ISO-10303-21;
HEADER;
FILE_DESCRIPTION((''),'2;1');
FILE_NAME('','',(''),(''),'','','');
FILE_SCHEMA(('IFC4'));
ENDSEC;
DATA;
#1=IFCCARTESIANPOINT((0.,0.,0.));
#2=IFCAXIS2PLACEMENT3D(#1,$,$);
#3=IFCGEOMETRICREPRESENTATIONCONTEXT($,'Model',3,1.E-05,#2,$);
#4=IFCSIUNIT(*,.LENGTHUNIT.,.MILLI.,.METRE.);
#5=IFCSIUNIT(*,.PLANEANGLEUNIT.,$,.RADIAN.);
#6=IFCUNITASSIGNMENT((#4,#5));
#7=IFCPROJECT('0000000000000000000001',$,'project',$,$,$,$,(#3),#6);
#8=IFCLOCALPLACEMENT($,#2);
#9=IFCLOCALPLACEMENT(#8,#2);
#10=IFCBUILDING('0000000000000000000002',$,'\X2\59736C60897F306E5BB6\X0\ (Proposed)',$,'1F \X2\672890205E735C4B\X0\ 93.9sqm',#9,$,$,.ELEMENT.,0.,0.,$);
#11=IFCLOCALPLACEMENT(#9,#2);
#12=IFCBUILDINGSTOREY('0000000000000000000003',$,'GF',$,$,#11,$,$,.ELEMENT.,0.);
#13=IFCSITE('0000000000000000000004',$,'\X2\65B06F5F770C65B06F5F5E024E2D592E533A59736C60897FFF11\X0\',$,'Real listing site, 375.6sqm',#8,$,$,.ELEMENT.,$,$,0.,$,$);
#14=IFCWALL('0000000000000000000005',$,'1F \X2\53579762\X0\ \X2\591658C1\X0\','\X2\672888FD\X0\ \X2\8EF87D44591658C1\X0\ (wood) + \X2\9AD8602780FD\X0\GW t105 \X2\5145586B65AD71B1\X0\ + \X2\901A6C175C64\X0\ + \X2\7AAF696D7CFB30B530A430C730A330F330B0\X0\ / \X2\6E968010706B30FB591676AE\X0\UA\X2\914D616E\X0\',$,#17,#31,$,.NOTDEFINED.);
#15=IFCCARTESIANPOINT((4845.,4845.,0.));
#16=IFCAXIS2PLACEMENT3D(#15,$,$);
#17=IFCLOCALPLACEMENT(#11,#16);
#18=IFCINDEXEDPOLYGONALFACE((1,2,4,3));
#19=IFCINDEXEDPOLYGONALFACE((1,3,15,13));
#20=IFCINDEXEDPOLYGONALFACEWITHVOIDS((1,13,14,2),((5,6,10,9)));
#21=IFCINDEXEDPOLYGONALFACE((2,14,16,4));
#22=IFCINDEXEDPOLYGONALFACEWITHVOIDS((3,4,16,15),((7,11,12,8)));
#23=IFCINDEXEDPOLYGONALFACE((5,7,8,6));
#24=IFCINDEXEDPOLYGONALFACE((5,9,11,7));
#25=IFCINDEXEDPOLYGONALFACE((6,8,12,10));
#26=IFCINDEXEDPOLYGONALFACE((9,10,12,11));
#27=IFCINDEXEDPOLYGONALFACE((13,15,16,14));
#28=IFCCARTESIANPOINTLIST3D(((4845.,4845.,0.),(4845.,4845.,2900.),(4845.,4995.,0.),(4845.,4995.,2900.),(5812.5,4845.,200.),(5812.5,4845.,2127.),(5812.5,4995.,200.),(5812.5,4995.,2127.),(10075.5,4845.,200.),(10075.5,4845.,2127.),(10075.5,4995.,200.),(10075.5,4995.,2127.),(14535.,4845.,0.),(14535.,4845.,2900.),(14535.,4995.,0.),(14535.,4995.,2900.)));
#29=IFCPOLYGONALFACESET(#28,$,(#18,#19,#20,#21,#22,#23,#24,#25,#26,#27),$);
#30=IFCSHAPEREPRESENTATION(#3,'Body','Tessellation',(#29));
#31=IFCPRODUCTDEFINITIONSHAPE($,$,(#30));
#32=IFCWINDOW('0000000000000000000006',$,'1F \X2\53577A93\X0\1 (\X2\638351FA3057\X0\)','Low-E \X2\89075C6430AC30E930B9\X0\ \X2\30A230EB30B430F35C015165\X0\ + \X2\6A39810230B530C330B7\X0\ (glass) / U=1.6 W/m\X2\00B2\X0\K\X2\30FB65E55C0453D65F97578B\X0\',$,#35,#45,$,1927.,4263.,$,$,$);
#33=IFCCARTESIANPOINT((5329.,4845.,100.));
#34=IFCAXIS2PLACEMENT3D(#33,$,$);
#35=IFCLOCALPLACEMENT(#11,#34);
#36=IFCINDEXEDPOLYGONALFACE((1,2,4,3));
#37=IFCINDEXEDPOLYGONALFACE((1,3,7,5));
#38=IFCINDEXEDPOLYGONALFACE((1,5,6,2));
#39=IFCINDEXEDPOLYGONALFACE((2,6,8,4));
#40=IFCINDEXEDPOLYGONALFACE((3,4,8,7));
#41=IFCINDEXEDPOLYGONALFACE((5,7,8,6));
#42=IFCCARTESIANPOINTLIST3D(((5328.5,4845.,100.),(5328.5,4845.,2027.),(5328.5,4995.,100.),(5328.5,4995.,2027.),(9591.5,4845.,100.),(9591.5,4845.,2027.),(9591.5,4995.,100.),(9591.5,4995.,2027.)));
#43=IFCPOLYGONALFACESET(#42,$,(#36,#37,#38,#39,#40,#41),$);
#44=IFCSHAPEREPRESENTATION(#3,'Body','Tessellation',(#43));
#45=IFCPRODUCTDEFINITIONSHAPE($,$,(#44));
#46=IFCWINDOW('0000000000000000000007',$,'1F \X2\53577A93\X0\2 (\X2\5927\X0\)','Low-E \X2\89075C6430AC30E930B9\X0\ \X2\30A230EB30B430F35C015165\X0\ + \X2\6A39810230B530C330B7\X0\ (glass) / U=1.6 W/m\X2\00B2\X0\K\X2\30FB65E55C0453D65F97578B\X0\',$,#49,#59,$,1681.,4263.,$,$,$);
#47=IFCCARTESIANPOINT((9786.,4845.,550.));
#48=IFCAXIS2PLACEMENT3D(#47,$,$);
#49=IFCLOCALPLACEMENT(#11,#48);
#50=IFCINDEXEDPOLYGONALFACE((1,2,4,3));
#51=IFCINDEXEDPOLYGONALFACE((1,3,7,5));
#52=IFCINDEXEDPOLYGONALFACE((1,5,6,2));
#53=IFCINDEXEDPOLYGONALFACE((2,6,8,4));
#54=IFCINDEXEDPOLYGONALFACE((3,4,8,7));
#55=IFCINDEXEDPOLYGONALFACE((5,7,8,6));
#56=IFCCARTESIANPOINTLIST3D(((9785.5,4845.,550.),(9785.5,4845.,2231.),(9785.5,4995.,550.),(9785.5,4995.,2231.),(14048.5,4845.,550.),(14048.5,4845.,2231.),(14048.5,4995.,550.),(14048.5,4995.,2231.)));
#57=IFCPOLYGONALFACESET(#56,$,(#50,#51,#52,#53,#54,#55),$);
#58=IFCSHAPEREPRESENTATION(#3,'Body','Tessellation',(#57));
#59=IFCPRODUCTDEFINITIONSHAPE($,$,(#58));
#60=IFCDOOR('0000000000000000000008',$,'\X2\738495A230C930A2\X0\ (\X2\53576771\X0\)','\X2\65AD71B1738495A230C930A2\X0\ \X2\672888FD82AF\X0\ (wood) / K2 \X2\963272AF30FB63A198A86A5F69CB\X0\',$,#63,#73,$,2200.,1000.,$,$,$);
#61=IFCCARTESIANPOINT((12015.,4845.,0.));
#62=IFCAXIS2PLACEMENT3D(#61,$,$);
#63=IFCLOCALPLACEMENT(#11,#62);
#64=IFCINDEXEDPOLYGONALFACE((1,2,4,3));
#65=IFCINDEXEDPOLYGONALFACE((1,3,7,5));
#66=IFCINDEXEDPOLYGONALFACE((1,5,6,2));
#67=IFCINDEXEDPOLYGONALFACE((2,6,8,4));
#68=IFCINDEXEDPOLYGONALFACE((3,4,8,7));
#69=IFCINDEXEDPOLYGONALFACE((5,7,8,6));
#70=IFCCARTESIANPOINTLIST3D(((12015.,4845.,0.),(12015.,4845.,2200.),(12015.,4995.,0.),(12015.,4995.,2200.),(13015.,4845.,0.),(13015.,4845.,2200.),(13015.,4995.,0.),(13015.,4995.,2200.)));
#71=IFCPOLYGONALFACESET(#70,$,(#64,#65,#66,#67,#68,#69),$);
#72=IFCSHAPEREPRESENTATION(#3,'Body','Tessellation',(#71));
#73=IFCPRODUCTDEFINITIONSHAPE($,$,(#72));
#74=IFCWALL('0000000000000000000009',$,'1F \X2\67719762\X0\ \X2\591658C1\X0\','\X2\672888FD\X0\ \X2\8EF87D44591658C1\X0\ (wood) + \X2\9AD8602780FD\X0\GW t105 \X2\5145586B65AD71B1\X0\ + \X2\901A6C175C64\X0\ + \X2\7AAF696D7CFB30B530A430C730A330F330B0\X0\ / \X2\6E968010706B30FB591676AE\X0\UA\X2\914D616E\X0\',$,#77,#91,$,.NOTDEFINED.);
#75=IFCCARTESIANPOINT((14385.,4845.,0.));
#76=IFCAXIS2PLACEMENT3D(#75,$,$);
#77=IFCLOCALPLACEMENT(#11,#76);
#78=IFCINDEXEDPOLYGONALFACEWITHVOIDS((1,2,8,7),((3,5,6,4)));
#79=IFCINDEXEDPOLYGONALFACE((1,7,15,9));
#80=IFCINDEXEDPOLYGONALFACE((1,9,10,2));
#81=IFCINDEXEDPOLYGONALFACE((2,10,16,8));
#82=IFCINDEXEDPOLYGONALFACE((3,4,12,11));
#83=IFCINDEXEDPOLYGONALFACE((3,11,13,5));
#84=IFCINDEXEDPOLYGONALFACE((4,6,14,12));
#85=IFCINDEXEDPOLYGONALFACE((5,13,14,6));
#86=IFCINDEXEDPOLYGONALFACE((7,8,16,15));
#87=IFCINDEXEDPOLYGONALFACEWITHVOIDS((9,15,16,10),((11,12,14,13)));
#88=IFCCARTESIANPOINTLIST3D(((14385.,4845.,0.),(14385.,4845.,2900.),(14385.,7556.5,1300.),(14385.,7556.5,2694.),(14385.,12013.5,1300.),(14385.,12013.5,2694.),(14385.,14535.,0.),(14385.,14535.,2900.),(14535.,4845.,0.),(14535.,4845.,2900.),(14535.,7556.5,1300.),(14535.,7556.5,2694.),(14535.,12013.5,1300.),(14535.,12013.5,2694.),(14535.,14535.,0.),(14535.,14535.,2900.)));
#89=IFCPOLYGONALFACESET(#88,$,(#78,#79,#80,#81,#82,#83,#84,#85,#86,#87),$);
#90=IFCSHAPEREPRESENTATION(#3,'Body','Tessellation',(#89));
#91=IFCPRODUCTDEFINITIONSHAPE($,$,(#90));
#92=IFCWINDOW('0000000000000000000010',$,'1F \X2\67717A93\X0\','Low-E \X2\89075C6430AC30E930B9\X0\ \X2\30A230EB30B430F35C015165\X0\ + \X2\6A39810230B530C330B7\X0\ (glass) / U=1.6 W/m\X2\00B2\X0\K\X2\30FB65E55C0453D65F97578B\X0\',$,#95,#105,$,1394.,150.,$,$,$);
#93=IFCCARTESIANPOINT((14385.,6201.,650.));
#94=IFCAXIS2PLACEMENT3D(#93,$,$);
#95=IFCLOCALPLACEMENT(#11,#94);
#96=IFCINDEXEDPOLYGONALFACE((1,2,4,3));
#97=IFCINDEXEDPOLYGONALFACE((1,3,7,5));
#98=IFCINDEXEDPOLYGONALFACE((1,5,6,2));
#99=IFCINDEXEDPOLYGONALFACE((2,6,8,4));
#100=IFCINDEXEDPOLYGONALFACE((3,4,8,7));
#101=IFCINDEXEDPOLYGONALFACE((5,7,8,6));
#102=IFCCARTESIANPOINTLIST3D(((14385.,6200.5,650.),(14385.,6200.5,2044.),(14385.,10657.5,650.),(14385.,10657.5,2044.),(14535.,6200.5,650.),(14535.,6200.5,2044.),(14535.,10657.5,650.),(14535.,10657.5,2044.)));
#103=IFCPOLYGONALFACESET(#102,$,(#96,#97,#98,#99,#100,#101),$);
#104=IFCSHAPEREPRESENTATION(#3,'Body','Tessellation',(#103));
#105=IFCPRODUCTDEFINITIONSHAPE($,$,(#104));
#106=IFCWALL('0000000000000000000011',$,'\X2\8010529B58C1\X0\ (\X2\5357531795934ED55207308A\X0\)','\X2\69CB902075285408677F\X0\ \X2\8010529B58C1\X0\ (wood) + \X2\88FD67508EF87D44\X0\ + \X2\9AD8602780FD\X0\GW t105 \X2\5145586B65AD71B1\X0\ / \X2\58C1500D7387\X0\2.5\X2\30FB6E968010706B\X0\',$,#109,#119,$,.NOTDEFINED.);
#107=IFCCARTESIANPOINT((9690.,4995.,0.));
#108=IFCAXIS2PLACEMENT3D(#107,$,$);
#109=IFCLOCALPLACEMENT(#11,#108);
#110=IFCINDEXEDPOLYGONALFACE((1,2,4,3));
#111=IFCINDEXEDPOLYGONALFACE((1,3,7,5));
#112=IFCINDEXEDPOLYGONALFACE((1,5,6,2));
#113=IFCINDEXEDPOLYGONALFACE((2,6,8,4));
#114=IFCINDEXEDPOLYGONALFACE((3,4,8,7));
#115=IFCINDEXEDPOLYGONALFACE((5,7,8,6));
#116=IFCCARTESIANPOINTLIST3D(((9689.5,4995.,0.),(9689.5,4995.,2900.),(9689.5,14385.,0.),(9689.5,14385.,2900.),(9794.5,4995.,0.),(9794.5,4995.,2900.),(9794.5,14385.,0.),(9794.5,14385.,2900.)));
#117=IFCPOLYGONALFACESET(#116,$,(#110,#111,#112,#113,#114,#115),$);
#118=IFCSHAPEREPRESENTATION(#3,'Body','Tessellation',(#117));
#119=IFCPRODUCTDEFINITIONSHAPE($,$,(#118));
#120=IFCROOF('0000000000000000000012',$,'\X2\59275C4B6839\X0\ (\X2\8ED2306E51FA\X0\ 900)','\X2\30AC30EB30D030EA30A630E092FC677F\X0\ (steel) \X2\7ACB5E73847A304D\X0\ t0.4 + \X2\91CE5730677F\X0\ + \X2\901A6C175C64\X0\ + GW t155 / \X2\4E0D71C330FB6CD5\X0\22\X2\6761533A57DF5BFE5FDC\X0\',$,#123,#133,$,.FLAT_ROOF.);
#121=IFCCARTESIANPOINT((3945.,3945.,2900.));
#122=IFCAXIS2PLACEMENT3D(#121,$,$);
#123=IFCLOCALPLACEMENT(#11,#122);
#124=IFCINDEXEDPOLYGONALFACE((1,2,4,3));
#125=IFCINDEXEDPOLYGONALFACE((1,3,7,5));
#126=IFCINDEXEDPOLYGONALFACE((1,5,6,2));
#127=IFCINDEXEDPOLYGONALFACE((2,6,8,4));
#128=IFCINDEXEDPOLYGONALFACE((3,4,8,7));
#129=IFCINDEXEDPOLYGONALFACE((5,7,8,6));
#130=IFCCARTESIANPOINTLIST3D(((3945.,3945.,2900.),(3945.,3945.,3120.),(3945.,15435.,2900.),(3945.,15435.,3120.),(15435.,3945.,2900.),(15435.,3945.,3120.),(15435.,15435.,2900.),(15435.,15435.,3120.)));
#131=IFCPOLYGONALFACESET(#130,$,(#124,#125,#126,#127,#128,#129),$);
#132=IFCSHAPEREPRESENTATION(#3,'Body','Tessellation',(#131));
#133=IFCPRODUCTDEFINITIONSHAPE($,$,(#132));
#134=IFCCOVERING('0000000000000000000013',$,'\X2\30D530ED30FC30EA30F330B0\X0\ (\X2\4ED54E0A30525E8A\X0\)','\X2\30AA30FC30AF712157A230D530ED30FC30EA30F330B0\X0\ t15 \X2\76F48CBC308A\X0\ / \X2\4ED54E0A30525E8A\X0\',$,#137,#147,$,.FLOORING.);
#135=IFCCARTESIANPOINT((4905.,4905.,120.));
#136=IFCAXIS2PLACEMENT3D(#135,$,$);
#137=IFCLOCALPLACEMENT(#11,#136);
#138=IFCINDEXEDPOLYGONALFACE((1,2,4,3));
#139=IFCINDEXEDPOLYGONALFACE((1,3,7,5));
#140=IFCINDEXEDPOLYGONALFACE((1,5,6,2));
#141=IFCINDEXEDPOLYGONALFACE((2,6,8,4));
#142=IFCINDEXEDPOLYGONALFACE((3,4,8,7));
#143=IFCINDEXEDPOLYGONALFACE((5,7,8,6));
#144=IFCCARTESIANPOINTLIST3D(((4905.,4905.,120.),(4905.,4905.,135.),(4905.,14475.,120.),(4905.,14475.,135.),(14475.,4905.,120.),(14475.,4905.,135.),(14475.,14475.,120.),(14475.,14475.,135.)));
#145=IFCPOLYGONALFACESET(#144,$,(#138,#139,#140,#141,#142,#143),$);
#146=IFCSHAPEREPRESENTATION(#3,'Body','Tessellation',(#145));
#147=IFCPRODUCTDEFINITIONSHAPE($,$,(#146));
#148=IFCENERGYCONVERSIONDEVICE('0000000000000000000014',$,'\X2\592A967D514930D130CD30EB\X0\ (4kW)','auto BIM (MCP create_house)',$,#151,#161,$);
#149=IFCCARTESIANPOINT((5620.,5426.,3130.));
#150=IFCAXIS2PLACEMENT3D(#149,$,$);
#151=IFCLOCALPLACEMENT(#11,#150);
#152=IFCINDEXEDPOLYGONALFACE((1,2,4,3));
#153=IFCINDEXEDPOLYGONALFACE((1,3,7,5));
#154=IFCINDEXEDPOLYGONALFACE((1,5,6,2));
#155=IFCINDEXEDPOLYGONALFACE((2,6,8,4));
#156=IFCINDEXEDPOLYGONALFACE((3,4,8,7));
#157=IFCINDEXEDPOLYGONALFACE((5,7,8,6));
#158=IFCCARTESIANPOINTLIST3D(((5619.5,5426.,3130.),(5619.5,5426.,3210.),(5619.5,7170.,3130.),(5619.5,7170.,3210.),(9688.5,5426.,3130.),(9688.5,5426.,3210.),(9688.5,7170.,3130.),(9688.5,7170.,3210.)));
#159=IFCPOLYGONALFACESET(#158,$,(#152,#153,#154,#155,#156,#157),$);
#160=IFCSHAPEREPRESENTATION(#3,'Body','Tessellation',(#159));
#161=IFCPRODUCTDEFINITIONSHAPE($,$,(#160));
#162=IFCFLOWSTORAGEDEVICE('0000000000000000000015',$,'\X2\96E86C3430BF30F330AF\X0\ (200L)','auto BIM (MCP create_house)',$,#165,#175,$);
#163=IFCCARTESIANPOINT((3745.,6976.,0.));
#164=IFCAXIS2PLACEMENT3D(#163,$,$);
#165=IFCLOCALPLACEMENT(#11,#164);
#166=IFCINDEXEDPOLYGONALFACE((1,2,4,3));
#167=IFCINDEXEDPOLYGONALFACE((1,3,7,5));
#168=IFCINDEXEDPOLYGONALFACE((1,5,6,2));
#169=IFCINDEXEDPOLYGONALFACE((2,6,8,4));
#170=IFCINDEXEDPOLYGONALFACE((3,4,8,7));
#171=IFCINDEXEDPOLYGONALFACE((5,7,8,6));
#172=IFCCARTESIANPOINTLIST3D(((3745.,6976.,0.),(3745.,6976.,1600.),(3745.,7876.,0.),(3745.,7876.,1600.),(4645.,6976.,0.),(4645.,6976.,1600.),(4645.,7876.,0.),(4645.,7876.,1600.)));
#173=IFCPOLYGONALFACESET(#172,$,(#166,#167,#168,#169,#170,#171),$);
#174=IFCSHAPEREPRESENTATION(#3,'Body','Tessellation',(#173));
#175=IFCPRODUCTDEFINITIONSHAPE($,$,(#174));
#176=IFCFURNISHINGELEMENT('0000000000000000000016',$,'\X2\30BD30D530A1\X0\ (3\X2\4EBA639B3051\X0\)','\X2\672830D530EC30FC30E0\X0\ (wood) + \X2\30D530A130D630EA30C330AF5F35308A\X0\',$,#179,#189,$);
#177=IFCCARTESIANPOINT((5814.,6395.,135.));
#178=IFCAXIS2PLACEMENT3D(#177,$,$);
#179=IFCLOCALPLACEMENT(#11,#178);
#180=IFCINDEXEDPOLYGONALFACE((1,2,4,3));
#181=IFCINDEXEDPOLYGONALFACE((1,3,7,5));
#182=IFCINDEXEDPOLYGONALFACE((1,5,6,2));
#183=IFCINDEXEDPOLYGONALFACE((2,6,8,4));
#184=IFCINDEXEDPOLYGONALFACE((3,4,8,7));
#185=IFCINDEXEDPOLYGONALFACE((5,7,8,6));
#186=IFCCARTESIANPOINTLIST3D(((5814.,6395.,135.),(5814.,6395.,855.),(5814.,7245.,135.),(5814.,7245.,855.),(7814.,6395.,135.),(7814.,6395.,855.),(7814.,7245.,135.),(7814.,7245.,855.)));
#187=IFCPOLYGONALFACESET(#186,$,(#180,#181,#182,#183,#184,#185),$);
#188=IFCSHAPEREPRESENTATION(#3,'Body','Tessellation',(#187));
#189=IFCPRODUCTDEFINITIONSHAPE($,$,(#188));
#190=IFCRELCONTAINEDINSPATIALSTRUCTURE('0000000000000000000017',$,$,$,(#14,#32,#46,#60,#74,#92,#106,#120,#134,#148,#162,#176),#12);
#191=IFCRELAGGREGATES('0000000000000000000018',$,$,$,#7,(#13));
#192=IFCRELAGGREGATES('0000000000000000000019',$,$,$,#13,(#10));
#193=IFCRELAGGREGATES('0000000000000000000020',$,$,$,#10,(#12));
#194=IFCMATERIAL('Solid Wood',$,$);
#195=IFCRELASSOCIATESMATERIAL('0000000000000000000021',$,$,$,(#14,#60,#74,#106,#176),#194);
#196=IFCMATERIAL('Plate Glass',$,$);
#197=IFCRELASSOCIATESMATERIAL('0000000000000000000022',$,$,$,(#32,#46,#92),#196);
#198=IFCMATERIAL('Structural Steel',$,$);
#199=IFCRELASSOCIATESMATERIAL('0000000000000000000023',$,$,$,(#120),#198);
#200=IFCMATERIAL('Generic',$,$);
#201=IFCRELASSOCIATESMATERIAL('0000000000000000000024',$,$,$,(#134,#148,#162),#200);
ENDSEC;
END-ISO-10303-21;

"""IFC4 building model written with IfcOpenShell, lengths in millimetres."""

from ifc_helpers import new_model, si_unit, frame, frame_2d, origin, place, context, project, spatial, rectangle, extrude, material, element, fill, save


model = new_model("IFC4")

# Units and contexts
model_context = context("Model", 3, precision=1e-05, world=origin())
ifc_project = project(units=[si_unit("LENGTHUNIT", "METRE", prefix="MILLI"), si_unit("PLANEANGLEUNIT", "RADIAN")], contexts=[model_context])

# Site, building, storey
site_placement = place(None, origin())
site = spatial("IfcSite", under=ifc_project, at=site_placement, Name="新潟県新潟市中央区女池西１", ObjectType="Real listing site, 375.6sqm", CompositionType="ELEMENT", RefElevation=0.0)
building_placement = place(site_placement, origin())
building = spatial("IfcBuilding", under=site, at=building_placement, Name="女池西の家 (Proposed)", ObjectType="1F 木造平屋 93.9sqm", CompositionType="ELEMENT", ElevationOfRefHeight=0.0, ElevationOfTerrain=0.0)
storey_placement = place(building_placement, origin())
storey = spatial("IfcBuildingStorey", under=building, at=storey_placement, Name="GF", CompositionType="ELEMENT", Elevation=0.0)

# Shared definitions
ifc_material_1 = material(Name="Solid Wood")

# Wall, openings, windows, door
wall_1_placement = place(storey_placement, frame((4845.0, 4845.0, 0.0)))
wall_1 = element("IfcWall", 1, at=wall_1_placement, inside=storey, material=ifc_material_1, Name="1F 南面 外壁", Description="木製 軸組外壁 (wood) + 高性能GW t105 充填断熱 + 通気層 + 窯業系サイディング / 準耐火・外皮UA配慮", PredefinedType="NOTDEFINED", context=model_context, shape_type="SweptSolid", body=[
    extrude(rectangle(XDim=9690.0, YDim=150.0, at=frame_2d((4845.0, 75.0))), frame((4845.0, 4845.0, 0.0)), (0.0, 0.0, 1.0), 2900.0),
])
opening_1_placement = place(storey_placement, frame((5329.0, 4845.0, 100.0)))
opening_1 = element("IfcOpeningElement", 2, at=opening_1_placement, cuts=wall_1, PredefinedType="NOTDEFINED", context=model_context, shape_type="SweptSolid", body=[
    extrude(rectangle(XDim=4263.0, YDim=150.0, at=frame_2d((2131.0, 75.0))), frame((5329.0, 4845.0, 100.0)), (0.0, 0.0, 1.0), 1927.0),
])
opening_2_placement = place(storey_placement, frame((9786.0, 4845.0, 550.0)))
opening_2 = element("IfcOpeningElement", 3, at=opening_2_placement, cuts=wall_1, PredefinedType="NOTDEFINED", context=model_context, shape_type="SweptSolid", body=[
    extrude(rectangle(XDim=4263.0, YDim=150.0, at=frame_2d((2131.0, 75.0))), frame((9786.0, 4845.0, 550.0)), (0.0, 0.0, 1.0), 1681.0),
])
opening_3_placement = place(storey_placement, frame((12015.0, 4845.0, 0.0)))
opening_3 = element("IfcOpeningElement", 4, at=opening_3_placement, cuts=wall_1, PredefinedType="NOTDEFINED", context=model_context, shape_type="SweptSolid", body=[
    extrude(rectangle(XDim=1000.0, YDim=150.0, at=frame_2d((500.0, 75.0))), frame((12015.0, 4845.0, 0.0)), (0.0, 0.0, 1.0), 2200.0),
])
ifc_material_2 = material(Name="Plate Glass")
window_1_placement = place(storey_placement, frame((5329.0, 4845.0, 100.0)))
window_1 = element("IfcWindow", 5, at=window_1_placement, inside=storey, material=ifc_material_2, Name="1F 南窓1 (掃出し)", Description="Low-E 複層ガラス アルゴン封入 + 樹脂サッシ (glass) / U=1.6 W/m²K・日射取得型", OverallHeight=1927.0, OverallWidth=4263.0, context=model_context, shape_type="SweptSolid", body=[
    extrude(rectangle(XDim=4263.0, YDim=150.0, at=frame_2d((2131.0, 75.0))), frame((5329.0, 4845.0, 100.0)), (0.0, 0.0, 1.0), 1927.0),
])
fill(opening_1, window_1)
window_2_placement = place(storey_placement, frame((9786.0, 4845.0, 550.0)))
window_2 = element("IfcWindow", 6, at=window_2_placement, inside=storey, material=ifc_material_2, Name="1F 南窓2 (大)", Description="Low-E 複層ガラス アルゴン封入 + 樹脂サッシ (glass) / U=1.6 W/m²K・日射取得型", OverallHeight=1681.0, OverallWidth=4263.0, context=model_context, shape_type="SweptSolid", body=[
    extrude(rectangle(XDim=4263.0, YDim=150.0, at=frame_2d((2131.0, 75.0))), frame((9786.0, 4845.0, 550.0)), (0.0, 0.0, 1.0), 1681.0),
])
fill(opening_2, window_2)
door_placement = place(storey_placement, frame((12015.0, 4845.0, 0.0)))
door = element("IfcDoor", 7, at=door_placement, inside=storey, material=ifc_material_1, Name="玄関ドア (南東)", Description="断熱玄関ドア 木製芯 (wood) / K2 防犯・採風機構", OverallHeight=2200.0, OverallWidth=1000.0, context=model_context, shape_type="SweptSolid", body=[
    extrude(rectangle(XDim=1000.0, YDim=150.0, at=frame_2d((500.0, 75.0))), frame((12015.0, 4845.0, 0.0)), (0.0, 0.0, 1.0), 2200.0),
])
fill(opening_3, door)

# Wall, opening, window
wall_2_placement = place(storey_placement, frame((14385.0, 4845.0, 0.0)))
wall_2 = element("IfcWall", 8, at=wall_2_placement, inside=storey, material=ifc_material_1, Name="1F 東面 外壁", Description="木製 軸組外壁 (wood) + 高性能GW t105 充填断熱 + 通気層 + 窯業系サイディング / 準耐火・外皮UA配慮", PredefinedType="NOTDEFINED", context=model_context, shape_type="SweptSolid", body=[
    extrude(rectangle(XDim=150.0, YDim=9690.0, at=frame_2d((75.0, 4845.0))), frame((14385.0, 4845.0, 0.0)), (0.0, 0.0, 1.0), 2900.0),
])
opening_4_placement = place(storey_placement, frame((14385.0, 6201.0, 650.0)))
opening_4 = element("IfcOpeningElement", 9, at=opening_4_placement, cuts=wall_2, PredefinedType="NOTDEFINED", context=model_context, shape_type="SweptSolid", body=[
    extrude(rectangle(XDim=150.0, YDim=4457.0, at=frame_2d((75.0, 2228.0))), frame((14385.0, 6201.0, 650.0)), (0.0, 0.0, 1.0), 1394.0),
])
window_3_placement = place(storey_placement, frame((14385.0, 6201.0, 650.0)))
window_3 = element("IfcWindow", 10, at=window_3_placement, inside=storey, material=ifc_material_2, Name="1F 東窓", Description="Low-E 複層ガラス アルゴン封入 + 樹脂サッシ (glass) / U=1.6 W/m²K・日射取得型", OverallHeight=1394.0, OverallWidth=150.0, context=model_context, shape_type="SweptSolid", body=[
    extrude(rectangle(XDim=150.0, YDim=4457.0, at=frame_2d((75.0, 2228.0))), frame((14385.0, 6201.0, 650.0)), (0.0, 0.0, 1.0), 1394.0),
])
fill(opening_4, window_3)

# Wall
wall_3_placement = place(storey_placement, frame((9690.0, 4995.0, 0.0)))
element("IfcWall", 11, at=wall_3_placement, inside=storey, material=ifc_material_1, Name="耐力壁 (南北間仕切り)", Description="構造用合板 耐力壁 (wood) + 製材軸組 + 高性能GW t105 充填断熱 / 壁倍率2.5・準耐火", PredefinedType="NOTDEFINED", context=model_context, shape_type="SweptSolid", body=[
    extrude(rectangle(XDim=105.0, YDim=9390.0, at=frame_2d((52.0, 4695.0))), frame((9690.0, 4995.0, 0.0)), (0.0, 0.0, 1.0), 2900.0),
])

# Roof
ifc_material_3 = material(Name="Structural Steel")
roof_placement = place(storey_placement, frame((3945.0, 3945.0, 2900.0)))
element("IfcRoof", 12, at=roof_placement, inside=storey, material=ifc_material_3, Name="大屋根 (軒の出 900)", Description="ガルバリウム鋼板 (steel) 立平葺き t0.4 + 野地板 + 通気層 + GW t155 / 不燃・法22条区域対応", PredefinedType="FLAT_ROOF", context=model_context, shape_type="SweptSolid", body=[
    extrude(rectangle(XDim=11490.0, YDim=11490.0, at=frame_2d((5745.0, 5745.0))), frame((3945.0, 3945.0, 2900.0)), (0.0, 0.0, 1.0), 220.0),
])

# Covering
ifc_material_4 = material(Name="Generic")
covering_placement = place(storey_placement, frame((4905.0, 4905.0, 120.0)))
element("IfcCovering", 13, at=covering_placement, inside=storey, material=ifc_material_4, Name="フローリング (仕上げ床)", Description="オーク無垢フローリング t15 直貼り / 仕上げ床", PredefinedType="FLOORING", context=model_context, shape_type="SweptSolid", body=[
    extrude(rectangle(XDim=9570.0, YDim=9570.0, at=frame_2d((4785.0, 4785.0))), frame((4905.0, 4905.0, 120.0)), (0.0, 0.0, 1.0), 15.0),
])

# Energy conversion device
energy_conversion_device_placement = place(storey_placement, frame((5620.0, 5426.0, 3130.0)))
element("IfcEnergyConversionDevice", 14, at=energy_conversion_device_placement, inside=storey, material=ifc_material_4, Name="太陽光パネル (4kW)", Description="auto BIM (MCP create_house)", context=model_context, shape_type="SweptSolid", body=[
    extrude(rectangle(XDim=4069.0, YDim=1744.0, at=frame_2d((2034.0, 872.0))), frame((5620.0, 5426.0, 3130.0)), (0.0, 0.0, 1.0), 80.0),
])

# Flow storage device
flow_storage_device_placement = place(storey_placement, frame((3745.0, 6976.0, 0.0)))
element("IfcFlowStorageDevice", 15, at=flow_storage_device_placement, inside=storey, material=ifc_material_4, Name="雨水タンク (200L)", Description="auto BIM (MCP create_house)", context=model_context, shape_type="SweptSolid", body=[
    extrude(rectangle(XDim=900.0, YDim=900.0, at=frame_2d((450.0, 450.0))), frame((3745.0, 6976.0, 0.0)), (0.0, 0.0, 1.0), 1600.0),
])

# Furnishing element
furnishing_1_placement = place(storey_placement, frame((5814.0, 6395.0, 135.0)))
element("IfcFurnishingElement", 16, at=furnishing_1_placement, inside=storey, material=ifc_material_1, Name="ソファ (3人掛け)", Description="木フレーム (wood) + ファブリック張り", context=model_context, shape_type="SweptSolid", body=[
    extrude(rectangle(XDim=2000.0, YDim=850.0, at=frame_2d((1000.0, 425.0))), frame((5814.0, 6395.0, 135.0)), (0.0, 0.0, 1.0), 720.0),
])

save(model, "model.ifc")
